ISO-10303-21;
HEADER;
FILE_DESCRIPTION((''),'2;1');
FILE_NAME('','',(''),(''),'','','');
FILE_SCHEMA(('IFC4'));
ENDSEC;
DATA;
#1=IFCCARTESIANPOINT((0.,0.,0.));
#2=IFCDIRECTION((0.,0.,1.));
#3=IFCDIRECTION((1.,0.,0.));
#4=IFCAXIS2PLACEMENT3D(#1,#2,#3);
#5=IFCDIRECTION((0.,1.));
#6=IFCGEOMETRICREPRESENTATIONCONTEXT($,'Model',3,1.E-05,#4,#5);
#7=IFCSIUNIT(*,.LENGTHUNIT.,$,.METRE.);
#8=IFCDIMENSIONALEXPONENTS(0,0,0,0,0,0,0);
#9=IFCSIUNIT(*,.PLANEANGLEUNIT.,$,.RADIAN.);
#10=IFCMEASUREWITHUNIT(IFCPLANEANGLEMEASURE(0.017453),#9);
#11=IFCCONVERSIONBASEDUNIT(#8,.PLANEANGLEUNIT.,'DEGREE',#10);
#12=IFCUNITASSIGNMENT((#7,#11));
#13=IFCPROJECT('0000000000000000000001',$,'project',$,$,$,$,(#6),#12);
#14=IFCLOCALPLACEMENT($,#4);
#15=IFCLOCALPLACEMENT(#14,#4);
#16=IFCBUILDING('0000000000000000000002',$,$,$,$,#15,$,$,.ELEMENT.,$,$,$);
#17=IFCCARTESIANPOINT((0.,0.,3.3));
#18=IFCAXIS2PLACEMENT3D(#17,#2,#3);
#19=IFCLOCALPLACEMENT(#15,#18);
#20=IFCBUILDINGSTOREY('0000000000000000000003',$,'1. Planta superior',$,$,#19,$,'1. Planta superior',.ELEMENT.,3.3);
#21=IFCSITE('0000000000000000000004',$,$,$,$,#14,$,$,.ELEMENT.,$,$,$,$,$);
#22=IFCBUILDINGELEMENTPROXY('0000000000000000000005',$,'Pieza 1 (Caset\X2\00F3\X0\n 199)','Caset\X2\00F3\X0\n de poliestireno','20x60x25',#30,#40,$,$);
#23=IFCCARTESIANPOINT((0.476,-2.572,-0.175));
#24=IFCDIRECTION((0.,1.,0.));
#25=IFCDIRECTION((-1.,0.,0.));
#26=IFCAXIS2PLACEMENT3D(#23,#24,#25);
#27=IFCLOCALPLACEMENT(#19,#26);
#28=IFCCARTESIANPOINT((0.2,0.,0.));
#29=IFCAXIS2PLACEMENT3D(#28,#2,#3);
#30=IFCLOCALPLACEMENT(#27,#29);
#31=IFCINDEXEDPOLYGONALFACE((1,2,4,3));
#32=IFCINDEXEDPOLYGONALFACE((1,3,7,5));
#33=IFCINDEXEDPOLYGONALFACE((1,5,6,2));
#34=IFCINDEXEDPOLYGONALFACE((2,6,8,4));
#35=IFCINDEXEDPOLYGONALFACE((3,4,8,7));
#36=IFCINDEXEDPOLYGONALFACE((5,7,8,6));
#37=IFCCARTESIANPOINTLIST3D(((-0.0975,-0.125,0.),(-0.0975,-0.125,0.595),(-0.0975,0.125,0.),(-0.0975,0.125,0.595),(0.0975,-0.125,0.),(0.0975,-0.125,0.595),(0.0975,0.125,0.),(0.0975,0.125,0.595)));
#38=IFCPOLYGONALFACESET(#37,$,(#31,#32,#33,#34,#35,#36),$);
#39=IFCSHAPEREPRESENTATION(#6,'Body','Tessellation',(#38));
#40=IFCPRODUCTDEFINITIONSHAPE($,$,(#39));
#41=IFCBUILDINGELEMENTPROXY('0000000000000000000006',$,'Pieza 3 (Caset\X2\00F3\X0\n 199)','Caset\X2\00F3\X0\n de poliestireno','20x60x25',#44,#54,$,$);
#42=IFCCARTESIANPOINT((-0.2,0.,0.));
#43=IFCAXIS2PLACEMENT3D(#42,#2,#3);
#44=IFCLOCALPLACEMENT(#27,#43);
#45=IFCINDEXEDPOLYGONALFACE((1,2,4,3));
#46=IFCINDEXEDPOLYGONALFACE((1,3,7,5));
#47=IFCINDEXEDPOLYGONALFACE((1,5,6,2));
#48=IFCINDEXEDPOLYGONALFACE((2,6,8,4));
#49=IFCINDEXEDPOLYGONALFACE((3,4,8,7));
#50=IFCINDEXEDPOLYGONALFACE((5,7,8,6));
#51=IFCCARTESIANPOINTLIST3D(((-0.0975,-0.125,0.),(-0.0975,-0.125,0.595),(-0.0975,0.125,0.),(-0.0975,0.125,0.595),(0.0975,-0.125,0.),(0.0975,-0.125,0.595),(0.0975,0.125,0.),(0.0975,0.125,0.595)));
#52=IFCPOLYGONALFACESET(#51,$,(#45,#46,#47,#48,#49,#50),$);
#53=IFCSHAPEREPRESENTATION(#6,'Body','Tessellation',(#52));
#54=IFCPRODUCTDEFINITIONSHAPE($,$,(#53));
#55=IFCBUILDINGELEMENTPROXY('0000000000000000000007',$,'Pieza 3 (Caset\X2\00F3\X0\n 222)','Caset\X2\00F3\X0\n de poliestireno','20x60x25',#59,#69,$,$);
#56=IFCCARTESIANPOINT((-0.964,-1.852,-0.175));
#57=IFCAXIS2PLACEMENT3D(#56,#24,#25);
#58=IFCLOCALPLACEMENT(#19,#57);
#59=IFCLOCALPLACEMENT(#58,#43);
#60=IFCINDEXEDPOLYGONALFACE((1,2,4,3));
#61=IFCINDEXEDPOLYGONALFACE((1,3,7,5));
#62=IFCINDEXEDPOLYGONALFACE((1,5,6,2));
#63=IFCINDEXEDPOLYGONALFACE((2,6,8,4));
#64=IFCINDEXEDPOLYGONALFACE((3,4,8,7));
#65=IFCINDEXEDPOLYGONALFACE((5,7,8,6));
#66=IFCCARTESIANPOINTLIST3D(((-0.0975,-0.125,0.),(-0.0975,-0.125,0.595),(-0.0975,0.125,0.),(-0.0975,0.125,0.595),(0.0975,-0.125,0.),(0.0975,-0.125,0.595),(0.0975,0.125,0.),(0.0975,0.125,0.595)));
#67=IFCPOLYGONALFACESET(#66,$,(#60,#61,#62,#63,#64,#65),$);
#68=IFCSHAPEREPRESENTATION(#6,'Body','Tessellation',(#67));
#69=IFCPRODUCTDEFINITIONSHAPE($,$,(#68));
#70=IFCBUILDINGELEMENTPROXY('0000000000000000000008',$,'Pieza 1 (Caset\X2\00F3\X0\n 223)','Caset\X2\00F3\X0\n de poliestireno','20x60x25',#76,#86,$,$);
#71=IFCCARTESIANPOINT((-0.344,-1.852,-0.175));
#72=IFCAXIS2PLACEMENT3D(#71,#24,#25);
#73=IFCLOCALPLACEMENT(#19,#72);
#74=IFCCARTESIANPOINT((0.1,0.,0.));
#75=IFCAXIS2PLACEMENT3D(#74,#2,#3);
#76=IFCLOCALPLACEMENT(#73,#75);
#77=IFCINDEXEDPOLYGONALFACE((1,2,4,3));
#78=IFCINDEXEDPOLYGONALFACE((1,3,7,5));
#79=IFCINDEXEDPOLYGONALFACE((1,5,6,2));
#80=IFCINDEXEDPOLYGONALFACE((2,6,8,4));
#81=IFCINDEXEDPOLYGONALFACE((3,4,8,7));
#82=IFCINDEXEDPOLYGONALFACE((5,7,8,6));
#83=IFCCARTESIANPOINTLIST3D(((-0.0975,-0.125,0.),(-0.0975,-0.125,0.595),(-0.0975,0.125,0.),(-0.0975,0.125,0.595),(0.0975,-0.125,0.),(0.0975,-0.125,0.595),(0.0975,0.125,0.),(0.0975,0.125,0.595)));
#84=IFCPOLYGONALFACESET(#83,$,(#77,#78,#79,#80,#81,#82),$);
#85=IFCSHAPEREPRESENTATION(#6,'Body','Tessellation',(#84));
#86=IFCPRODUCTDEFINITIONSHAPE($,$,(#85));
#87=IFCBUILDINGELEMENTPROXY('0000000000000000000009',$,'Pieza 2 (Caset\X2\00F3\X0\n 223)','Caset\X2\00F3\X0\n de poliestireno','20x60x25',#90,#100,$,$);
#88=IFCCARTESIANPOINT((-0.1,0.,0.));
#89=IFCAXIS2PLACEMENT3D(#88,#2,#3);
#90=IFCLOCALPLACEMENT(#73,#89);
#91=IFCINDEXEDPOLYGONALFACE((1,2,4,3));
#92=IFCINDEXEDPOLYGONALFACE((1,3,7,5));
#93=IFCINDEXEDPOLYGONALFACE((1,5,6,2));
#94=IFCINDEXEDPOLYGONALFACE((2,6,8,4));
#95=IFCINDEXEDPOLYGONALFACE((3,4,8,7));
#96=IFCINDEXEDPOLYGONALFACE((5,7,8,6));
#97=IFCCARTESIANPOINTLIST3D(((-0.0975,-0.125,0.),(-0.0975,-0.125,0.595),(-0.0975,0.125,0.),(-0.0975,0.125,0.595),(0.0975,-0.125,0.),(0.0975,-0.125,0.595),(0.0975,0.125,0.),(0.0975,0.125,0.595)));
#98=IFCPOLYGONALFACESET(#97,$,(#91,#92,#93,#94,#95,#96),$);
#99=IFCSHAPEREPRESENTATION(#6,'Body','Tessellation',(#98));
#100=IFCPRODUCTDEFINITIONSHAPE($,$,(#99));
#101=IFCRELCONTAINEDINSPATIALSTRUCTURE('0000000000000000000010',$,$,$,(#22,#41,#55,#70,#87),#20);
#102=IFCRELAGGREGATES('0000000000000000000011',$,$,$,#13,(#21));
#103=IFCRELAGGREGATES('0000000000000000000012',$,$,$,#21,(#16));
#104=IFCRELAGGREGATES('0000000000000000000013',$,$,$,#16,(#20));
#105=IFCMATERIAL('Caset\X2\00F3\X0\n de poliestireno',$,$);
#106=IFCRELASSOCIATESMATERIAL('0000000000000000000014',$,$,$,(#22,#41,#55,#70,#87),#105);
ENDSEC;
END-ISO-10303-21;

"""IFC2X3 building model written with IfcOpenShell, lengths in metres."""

from ifc_helpers import new_model, entity, si_unit, converted_unit, direction, frame, origin_with_axes, origin_2d_with_axis, place, context, project, spatial, rectangle, extrude, source, transform, mapped, material, element, save


model = new_model("IFC2X3")

# Units and contexts
model_context = context("Model", 3, precision=1e-05, world=origin_with_axes(), true_north=direction((0.0, 1.0)))
ifc_project = project(units=[si_unit("LENGTHUNIT", "METRE"), converted_unit("PLANEANGLEUNIT", "DEGREE", entity("IfcPlaneAngleMeasure", 0.017453), si_unit("PLANEANGLEUNIT", "RADIAN"), dimensions=[0, 0, 0, 0, 0, 0, 0])], contexts=[model_context])

# Site, building, storey
site_placement = place(None, origin_with_axes())
site = spatial("IfcSite", under=ifc_project, at=site_placement, CompositionType="ELEMENT")
building_placement = place(site_placement, origin_with_axes())
building = spatial("IfcBuilding", under=site, at=building_placement, CompositionType="ELEMENT")
storey_placement = place(building_placement, frame((0.0, 0.0, 3.3), z_axis=(0.0, 0.0, 1.0), x_axis=(1.0, 0.0, 0.0)))
storey = spatial("IfcBuildingStorey", under=building, at=storey_placement, Name="1. Planta superior", LongName="1. Planta superior", CompositionType="ELEMENT", Elevation=3.3)

# Building element proxies
ifc_material_1 = material(Name="Casetón de poliestireno")
shared_shape = source(origin_with_axes(), model_context, "Body", "SweptSolid", [
    extrude(rectangle(XDim=0.195, YDim=0.25, at=origin_2d_with_axis()), origin_with_axes(), (0.0, 0.0, 1.0), 0.595),
])
placement_1 = place(storey_placement, frame((0.476, -2.572, -0.175), z_axis=(0.0, 1.0, 0.0), x_axis=(-1.0, 0.0, 0.0)))
for number, where, z_axis, x_axis, name in (
    (1, (0.2, 0.0, 0.0), (0.0, 0.0, 1.0), (1.0, 0.0, 0.0), "Pieza 1 (Casetón 199)"),
    (2, (-0.2, 0.0, 0.0), (0.0, 0.0, 1.0), (1.0, 0.0, 0.0), "Pieza 3 (Casetón 199)"),
):
    element("IfcBuildingElementProxy", number, at=place(placement_1, frame(where, z_axis=z_axis, x_axis=x_axis)), inside=storey, material=ifc_material_1, Name=name, Description="Casetón de poliestireno", ObjectType="20x60x25", context=model_context, shape_type="MappedRepresentation", body=[
        mapped(shared_shape, transform((0.0, 0.0, 0.0), x_axis=(1.0, 0.0, 0.0), y_axis=(0.0, 1.0, 0.0), z_axis=(0.0, 0.0, 1.0))),
    ])
placement_2 = place(storey_placement, frame((-0.964, -1.852, -0.175), z_axis=(0.0, 1.0, 0.0), x_axis=(-1.0, 0.0, 0.0)))
for number, where, z_axis, x_axis, name in (
    (3, (-0.2, 0.0, 0.0), (0.0, 0.0, 1.0), (1.0, 0.0, 0.0), "Pieza 3 (Casetón 222)"),
):
    element("IfcBuildingElementProxy", number, at=place(placement_2, frame(where, z_axis=z_axis, x_axis=x_axis)), inside=storey, material=ifc_material_1, Name=name, Description="Casetón de poliestireno", ObjectType="20x60x25", context=model_context, shape_type="MappedRepresentation", body=[
        mapped(shared_shape, transform((0.0, 0.0, 0.0), x_axis=(1.0, 0.0, 0.0), y_axis=(0.0, 1.0, 0.0), z_axis=(0.0, 0.0, 1.0))),
    ])
placement_3 = place(storey_placement, frame((-0.344, -1.852, -0.175), z_axis=(0.0, 1.0, 0.0), x_axis=(-1.0, 0.0, 0.0)))
for number, where, z_axis, x_axis, name in (
    (4, (0.1, 0.0, 0.0), (0.0, 0.0, 1.0), (1.0, 0.0, 0.0), "Pieza 1 (Casetón 223)"),
    (5, (-0.1, 0.0, 0.0), (0.0, 0.0, 1.0), (1.0, 0.0, 0.0), "Pieza 2 (Casetón 223)"),
):
    element("IfcBuildingElementProxy", number, at=place(placement_3, frame(where, z_axis=z_axis, x_axis=x_axis)), inside=storey, material=ifc_material_1, Name=name, Description="Casetón de poliestireno", ObjectType="20x60x25", context=model_context, shape_type="MappedRepresentation", body=[
        mapped(shared_shape, transform((0.0, 0.0, 0.0), x_axis=(1.0, 0.0, 0.0), y_axis=(0.0, 1.0, 0.0), z_axis=(0.0, 0.0, 1.0))),
    ])

save(model, "model.ifc")
